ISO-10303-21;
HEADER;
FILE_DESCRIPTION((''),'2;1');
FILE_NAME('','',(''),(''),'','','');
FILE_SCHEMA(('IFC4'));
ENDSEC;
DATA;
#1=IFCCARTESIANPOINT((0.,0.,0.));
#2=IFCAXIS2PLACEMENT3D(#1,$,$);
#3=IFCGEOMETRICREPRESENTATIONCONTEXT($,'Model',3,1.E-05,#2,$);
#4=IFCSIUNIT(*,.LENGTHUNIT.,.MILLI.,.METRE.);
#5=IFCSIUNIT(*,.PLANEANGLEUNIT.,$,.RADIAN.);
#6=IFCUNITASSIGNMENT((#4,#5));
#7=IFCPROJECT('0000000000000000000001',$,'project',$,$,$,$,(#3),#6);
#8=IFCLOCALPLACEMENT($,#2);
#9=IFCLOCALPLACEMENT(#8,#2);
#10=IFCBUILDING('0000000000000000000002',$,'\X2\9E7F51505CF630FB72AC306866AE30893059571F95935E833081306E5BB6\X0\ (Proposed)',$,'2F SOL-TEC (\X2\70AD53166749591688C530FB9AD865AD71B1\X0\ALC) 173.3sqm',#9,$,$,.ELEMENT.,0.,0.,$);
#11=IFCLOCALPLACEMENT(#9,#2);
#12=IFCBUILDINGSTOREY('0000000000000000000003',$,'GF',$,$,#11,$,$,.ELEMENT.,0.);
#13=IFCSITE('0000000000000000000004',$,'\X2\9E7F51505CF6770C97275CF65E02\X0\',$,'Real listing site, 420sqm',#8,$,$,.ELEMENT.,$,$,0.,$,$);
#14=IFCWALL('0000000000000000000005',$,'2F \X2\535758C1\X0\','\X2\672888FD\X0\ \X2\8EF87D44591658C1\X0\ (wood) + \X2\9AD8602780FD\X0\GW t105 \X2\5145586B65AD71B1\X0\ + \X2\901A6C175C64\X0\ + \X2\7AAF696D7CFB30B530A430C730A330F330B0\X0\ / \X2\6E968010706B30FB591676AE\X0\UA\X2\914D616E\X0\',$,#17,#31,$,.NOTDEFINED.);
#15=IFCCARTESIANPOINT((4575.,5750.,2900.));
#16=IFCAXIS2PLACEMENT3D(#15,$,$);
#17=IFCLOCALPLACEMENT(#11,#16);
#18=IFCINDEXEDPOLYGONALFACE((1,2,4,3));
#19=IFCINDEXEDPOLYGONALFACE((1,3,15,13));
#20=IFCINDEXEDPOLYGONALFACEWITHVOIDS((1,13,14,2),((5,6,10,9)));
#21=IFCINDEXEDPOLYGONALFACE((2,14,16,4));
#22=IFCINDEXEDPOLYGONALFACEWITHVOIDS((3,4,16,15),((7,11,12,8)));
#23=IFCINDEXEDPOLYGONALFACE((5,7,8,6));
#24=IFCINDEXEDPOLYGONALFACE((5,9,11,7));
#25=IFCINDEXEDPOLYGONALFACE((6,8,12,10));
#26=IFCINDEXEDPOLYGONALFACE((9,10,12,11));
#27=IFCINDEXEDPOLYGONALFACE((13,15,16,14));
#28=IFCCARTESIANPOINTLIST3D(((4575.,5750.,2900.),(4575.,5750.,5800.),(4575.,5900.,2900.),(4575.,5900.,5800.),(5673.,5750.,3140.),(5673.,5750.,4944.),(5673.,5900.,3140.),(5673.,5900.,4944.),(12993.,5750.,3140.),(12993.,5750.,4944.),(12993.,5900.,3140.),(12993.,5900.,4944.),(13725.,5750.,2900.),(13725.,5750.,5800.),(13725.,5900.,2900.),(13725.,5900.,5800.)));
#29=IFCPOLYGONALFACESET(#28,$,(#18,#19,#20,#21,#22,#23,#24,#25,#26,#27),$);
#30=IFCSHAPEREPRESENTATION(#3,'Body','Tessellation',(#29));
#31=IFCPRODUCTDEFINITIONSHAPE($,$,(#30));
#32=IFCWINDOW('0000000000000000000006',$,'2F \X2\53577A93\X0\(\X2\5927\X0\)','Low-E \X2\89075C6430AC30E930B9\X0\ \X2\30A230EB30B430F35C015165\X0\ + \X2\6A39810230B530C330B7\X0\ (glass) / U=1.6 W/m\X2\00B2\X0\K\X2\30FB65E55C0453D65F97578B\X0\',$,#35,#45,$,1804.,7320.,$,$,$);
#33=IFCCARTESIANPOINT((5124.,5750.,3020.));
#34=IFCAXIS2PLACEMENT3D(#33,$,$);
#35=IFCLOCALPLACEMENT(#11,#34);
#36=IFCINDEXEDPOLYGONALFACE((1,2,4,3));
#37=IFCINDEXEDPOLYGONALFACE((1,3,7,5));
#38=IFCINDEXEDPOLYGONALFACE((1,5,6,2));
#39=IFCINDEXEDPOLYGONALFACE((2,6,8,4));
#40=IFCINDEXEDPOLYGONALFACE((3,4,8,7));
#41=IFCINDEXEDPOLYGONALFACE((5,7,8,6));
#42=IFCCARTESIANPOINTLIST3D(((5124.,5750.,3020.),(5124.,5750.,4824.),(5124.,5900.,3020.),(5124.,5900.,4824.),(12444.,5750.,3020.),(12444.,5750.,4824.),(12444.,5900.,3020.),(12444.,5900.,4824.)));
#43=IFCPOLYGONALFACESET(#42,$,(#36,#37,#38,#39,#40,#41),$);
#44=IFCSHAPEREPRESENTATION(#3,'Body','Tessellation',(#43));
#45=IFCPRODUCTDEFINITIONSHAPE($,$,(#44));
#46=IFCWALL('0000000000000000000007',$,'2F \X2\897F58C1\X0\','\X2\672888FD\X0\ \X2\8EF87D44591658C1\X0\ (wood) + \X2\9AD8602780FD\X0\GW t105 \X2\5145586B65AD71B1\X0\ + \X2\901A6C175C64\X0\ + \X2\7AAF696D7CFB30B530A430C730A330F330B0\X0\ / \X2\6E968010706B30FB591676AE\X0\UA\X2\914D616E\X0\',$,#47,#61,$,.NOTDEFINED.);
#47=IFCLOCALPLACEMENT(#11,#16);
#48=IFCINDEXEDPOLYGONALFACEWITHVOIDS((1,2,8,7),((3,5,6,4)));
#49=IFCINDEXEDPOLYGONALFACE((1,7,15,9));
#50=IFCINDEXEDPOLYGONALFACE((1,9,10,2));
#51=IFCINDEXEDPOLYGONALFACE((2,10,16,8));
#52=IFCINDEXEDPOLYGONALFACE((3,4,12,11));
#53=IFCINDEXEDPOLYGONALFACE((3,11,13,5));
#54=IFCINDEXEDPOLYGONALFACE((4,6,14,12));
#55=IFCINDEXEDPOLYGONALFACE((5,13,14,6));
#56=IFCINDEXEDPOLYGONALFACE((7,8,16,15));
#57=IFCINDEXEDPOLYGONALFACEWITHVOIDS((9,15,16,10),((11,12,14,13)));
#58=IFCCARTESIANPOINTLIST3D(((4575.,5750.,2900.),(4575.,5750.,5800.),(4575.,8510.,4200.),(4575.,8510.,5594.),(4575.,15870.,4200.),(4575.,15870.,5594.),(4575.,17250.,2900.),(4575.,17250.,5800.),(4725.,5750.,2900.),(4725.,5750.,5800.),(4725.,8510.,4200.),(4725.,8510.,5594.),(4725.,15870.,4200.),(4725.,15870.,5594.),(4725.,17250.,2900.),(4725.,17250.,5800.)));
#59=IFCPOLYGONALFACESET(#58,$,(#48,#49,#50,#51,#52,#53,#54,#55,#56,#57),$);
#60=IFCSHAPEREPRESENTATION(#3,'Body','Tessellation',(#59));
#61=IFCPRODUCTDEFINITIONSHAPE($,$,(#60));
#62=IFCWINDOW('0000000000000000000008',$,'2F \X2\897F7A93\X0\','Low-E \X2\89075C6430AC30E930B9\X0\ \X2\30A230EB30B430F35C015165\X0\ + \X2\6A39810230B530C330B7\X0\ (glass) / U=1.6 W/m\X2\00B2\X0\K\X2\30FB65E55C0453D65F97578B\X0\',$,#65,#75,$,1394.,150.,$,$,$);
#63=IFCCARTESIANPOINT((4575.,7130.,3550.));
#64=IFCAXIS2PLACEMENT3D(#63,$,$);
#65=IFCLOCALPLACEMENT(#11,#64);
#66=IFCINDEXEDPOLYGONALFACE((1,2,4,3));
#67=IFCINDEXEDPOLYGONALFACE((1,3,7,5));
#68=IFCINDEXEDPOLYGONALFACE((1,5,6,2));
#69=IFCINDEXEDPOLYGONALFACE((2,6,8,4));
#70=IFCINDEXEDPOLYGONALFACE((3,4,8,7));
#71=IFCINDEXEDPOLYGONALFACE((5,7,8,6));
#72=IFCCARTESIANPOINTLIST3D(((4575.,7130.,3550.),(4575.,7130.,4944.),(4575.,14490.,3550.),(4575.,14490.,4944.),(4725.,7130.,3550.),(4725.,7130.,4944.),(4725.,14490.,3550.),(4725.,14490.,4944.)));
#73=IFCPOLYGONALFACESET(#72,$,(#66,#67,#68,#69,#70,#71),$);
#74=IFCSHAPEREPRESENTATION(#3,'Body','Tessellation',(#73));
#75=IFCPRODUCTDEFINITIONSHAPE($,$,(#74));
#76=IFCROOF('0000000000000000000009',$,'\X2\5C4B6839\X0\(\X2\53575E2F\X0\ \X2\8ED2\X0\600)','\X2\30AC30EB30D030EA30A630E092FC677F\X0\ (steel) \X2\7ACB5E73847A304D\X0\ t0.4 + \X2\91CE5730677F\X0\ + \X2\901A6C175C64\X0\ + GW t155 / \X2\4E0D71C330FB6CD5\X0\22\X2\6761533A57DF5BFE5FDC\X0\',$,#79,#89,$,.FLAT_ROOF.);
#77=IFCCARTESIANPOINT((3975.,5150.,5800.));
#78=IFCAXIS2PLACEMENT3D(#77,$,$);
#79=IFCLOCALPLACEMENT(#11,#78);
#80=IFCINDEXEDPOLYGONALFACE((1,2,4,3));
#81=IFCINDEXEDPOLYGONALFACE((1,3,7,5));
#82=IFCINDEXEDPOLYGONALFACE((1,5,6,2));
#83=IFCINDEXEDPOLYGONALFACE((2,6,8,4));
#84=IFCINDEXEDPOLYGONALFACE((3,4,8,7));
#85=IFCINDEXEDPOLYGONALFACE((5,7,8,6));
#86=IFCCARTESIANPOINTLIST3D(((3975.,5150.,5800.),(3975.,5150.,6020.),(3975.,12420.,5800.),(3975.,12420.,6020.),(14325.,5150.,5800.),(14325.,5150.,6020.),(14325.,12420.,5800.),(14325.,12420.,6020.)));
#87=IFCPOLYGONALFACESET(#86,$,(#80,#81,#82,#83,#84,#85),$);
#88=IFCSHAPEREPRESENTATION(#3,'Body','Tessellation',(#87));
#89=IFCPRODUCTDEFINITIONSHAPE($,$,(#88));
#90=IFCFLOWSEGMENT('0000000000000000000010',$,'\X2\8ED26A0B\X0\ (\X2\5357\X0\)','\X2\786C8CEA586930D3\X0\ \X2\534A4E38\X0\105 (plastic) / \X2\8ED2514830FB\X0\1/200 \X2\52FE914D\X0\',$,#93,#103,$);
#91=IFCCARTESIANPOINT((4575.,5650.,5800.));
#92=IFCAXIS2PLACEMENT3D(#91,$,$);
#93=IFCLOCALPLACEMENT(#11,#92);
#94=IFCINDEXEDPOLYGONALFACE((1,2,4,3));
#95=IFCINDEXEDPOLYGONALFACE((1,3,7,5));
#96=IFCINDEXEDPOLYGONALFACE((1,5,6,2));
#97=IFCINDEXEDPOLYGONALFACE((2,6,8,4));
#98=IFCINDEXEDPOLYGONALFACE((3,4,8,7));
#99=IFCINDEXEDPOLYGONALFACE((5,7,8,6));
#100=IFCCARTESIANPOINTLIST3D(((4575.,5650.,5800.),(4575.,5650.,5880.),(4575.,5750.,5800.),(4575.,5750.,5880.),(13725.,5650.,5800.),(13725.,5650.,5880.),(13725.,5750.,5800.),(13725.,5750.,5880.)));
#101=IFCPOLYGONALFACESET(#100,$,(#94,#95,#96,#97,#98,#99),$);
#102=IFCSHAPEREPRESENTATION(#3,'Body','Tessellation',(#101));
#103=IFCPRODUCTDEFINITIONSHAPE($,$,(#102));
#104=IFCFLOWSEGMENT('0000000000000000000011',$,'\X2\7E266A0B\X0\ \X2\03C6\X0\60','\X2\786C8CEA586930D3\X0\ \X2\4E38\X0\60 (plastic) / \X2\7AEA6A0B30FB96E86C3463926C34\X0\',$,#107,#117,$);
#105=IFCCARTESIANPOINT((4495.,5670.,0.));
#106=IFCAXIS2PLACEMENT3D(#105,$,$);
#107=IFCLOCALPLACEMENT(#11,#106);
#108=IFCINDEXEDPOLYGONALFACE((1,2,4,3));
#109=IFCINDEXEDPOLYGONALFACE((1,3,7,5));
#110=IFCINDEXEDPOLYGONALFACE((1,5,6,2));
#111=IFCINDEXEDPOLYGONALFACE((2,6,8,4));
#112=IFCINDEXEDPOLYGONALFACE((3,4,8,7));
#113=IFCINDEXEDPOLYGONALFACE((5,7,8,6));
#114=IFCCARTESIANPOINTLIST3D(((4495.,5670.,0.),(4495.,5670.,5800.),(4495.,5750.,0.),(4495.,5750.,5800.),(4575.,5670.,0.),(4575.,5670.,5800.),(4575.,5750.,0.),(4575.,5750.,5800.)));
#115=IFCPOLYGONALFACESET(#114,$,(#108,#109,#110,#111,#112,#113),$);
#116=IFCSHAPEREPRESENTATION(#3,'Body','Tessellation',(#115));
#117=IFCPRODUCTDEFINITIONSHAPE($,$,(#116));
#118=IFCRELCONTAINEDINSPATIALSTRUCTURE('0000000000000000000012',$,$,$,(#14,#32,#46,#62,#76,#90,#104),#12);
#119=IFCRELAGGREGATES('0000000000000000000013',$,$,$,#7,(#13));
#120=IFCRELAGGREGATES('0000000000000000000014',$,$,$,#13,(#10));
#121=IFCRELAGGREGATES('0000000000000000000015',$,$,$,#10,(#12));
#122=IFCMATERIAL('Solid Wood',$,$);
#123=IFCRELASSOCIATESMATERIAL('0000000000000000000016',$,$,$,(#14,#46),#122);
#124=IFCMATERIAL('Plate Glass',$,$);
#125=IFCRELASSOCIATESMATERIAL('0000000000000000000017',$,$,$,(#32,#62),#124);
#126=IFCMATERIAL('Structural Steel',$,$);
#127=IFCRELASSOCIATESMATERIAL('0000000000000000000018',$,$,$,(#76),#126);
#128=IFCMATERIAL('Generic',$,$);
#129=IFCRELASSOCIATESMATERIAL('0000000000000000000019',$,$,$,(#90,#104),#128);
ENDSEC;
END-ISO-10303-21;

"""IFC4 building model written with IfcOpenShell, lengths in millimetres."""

from ifc_helpers import new_model, si_unit, frame, frame_2d, origin, place, context, project, spatial, rectangle, extrude, material, element, fill, save


model = new_model("IFC4")

# Units and contexts
model_context = context("Model", 3, precision=1e-05, world=origin())
ifc_project = project(units=[si_unit("LENGTHUNIT", "METRE", prefix="MILLI"), si_unit("PLANEANGLEUNIT", "RADIAN")], contexts=[model_context])

# Site, building, storey
site_placement = place(None, origin())
site = spatial("IfcSite", under=ifc_project, at=site_placement, Name="鹿児島県霧島市", ObjectType="Real listing site, 420sqm", CompositionType="ELEMENT", RefElevation=0.0)
building_placement = place(site_placement, origin())
building = spatial("IfcBuilding", under=site, at=building_placement, Name="鹿児島・犬と暮らす土間広めの家 (Proposed)", ObjectType="2F SOL-TEC (炭化杉外装・高断熱ALC) 173.3sqm", CompositionType="ELEMENT", ElevationOfRefHeight=0.0, ElevationOfTerrain=0.0)
storey_placement = place(building_placement, origin())
storey = spatial("IfcBuildingStorey", under=building, at=storey_placement, Name="GF", CompositionType="ELEMENT", Elevation=0.0)

# Shared definitions
ifc_material_1 = material(Name="Solid Wood")

# Shared definitions
ifc_material_2 = material(Name="Plate Glass")

# Walls, openings, windows
wall_1_placement = place(storey_placement, frame((4575.0, 5750.0, 2900.0)))
wall_1 = element("IfcWall", 1, at=wall_1_placement, inside=storey, material=ifc_material_1, Name="2F 南壁", Description="木製 軸組外壁 (wood) + 高性能GW t105 充填断熱 + 通気層 + 窯業系サイディング / 準耐火・外皮UA配慮", PredefinedType="NOTDEFINED", context=model_context, shape_type="SweptSolid", body=[
    extrude(rectangle(XDim=9150.0, YDim=150.0, at=frame_2d((4575.0, 75.0))), frame((4575.0, 5750.0, 2900.0)), (0.0, 0.0, 1.0), 2900.0),
])
opening_1_placement = place(storey_placement, frame((5124.0, 5750.0, 3020.0)))
opening_1 = element("IfcOpeningElement", 2, at=opening_1_placement, cuts=wall_1, PredefinedType="NOTDEFINED", context=model_context, shape_type="SweptSolid", body=[
    extrude(rectangle(XDim=7320.0, YDim=150.0, at=frame_2d((3660.0, 75.0))), frame((5124.0, 5750.0, 3020.0)), (0.0, 0.0, 1.0), 1804.0),
])
window_1_placement = place(storey_placement, frame((5124.0, 5750.0, 3020.0)))
window_1 = element("IfcWindow", 3, at=window_1_placement, inside=storey, material=ifc_material_2, Name="2F 南窓(大)", Description="Low-E 複層ガラス アルゴン封入 + 樹脂サッシ (glass) / U=1.6 W/m²K・日射取得型", OverallHeight=1804.0, OverallWidth=7320.0, context=model_context, shape_type="SweptSolid", body=[
    extrude(rectangle(XDim=7320.0, YDim=150.0, at=frame_2d((3660.0, 75.0))), frame((5124.0, 5750.0, 3020.0)), (0.0, 0.0, 1.0), 1804.0),
])
fill(opening_1, window_1)
wall_2_placement = place(storey_placement, frame((4575.0, 5750.0, 2900.0)))
wall_2 = element("IfcWall", 4, at=wall_2_placement, inside=storey, material=ifc_material_1, Name="2F 西壁", Description="木製 軸組外壁 (wood) + 高性能GW t105 充填断熱 + 通気層 + 窯業系サイディング / 準耐火・外皮UA配慮", PredefinedType="NOTDEFINED", context=model_context, shape_type="SweptSolid", body=[
    extrude(rectangle(XDim=150.0, YDim=11500.0, at=frame_2d((75.0, 5750.0))), frame((4575.0, 5750.0, 2900.0)), (0.0, 0.0, 1.0), 2900.0),
])
opening_2_placement = place(storey_placement, frame((4575.0, 7130.0, 3550.0)))
opening_2 = element("IfcOpeningElement", 5, at=opening_2_placement, cuts=wall_2, PredefinedType="NOTDEFINED", context=model_context, shape_type="SweptSolid", body=[
    extrude(rectangle(XDim=150.0, YDim=7360.0, at=frame_2d((75.0, 3680.0))), frame((4575.0, 7130.0, 3550.0)), (0.0, 0.0, 1.0), 1394.0),
])
window_2_placement = place(storey_placement, frame((4575.0, 7130.0, 3550.0)))
window_2 = element("IfcWindow", 6, at=window_2_placement, inside=storey, material=ifc_material_2, Name="2F 西窓", Description="Low-E 複層ガラス アルゴン封入 + 樹脂サッシ (glass) / U=1.6 W/m²K・日射取得型", OverallHeight=1394.0, OverallWidth=150.0, context=model_context, shape_type="SweptSolid", body=[
    extrude(rectangle(XDim=150.0, YDim=7360.0, at=frame_2d((75.0, 3680.0))), frame((4575.0, 7130.0, 3550.0)), (0.0, 0.0, 1.0), 1394.0),
])
fill(opening_2, window_2)

# Roof
ifc_material_3 = material(Name="Structural Steel")
for number, where, name in (
    (7, (3975.0, 5150.0, 5800.0), "屋根(南帯 軒600)"),
):
    element("IfcRoof", number, at=place(storey_placement, frame(where)), inside=storey, material=ifc_material_3, Name=name, Description="ガルバリウム鋼板 (steel) 立平葺き t0.4 + 野地板 + 通気層 + GW t155 / 不燃・法22条区域対応", PredefinedType="FLAT_ROOF", context=model_context, shape_type="SweptSolid", body=[
        extrude(rectangle(XDim=10350.0, YDim=7270.0, at=frame_2d((5175.0, 3635.0))), frame((3975.0, 5150.0, 5800.0)), (0.0, 0.0, 1.0), 220.0),
    ])

# Flow segments
ifc_material_4 = material(Name="Generic")
flow_segment_1_placement = place(storey_placement, frame((4575.0, 5650.0, 5800.0)))
element("IfcFlowSegment", 8, at=flow_segment_1_placement, inside=storey, material=ifc_material_4, Name="軒樋 (南)", Description="硬質塩ビ 半丸105 (plastic) / 軒先・1/200 勾配", context=model_context, shape_type="SweptSolid", body=[
    extrude(rectangle(XDim=9150.0, YDim=100.0, at=frame_2d((4575.0, 50.0))), frame((4575.0, 5650.0, 5800.0)), (0.0, 0.0, 1.0), 80.0),
])
flow_segment_2_placement = place(storey_placement, frame((4495.0, 5670.0, 0.0)))
element("IfcFlowSegment", 9, at=flow_segment_2_placement, inside=storey, material=ifc_material_4, Name="縦樋 φ60", Description="硬質塩ビ 丸60 (plastic) / 竪樋・雨水排水", context=model_context, shape_type="SweptSolid", body=[
    extrude(rectangle(XDim=80.0, YDim=80.0, at=frame_2d((40.0, 40.0))), frame((4495.0, 5670.0, 0.0)), (0.0, 0.0, 1.0), 5800.0),
])

save(model, "model.ifc")
